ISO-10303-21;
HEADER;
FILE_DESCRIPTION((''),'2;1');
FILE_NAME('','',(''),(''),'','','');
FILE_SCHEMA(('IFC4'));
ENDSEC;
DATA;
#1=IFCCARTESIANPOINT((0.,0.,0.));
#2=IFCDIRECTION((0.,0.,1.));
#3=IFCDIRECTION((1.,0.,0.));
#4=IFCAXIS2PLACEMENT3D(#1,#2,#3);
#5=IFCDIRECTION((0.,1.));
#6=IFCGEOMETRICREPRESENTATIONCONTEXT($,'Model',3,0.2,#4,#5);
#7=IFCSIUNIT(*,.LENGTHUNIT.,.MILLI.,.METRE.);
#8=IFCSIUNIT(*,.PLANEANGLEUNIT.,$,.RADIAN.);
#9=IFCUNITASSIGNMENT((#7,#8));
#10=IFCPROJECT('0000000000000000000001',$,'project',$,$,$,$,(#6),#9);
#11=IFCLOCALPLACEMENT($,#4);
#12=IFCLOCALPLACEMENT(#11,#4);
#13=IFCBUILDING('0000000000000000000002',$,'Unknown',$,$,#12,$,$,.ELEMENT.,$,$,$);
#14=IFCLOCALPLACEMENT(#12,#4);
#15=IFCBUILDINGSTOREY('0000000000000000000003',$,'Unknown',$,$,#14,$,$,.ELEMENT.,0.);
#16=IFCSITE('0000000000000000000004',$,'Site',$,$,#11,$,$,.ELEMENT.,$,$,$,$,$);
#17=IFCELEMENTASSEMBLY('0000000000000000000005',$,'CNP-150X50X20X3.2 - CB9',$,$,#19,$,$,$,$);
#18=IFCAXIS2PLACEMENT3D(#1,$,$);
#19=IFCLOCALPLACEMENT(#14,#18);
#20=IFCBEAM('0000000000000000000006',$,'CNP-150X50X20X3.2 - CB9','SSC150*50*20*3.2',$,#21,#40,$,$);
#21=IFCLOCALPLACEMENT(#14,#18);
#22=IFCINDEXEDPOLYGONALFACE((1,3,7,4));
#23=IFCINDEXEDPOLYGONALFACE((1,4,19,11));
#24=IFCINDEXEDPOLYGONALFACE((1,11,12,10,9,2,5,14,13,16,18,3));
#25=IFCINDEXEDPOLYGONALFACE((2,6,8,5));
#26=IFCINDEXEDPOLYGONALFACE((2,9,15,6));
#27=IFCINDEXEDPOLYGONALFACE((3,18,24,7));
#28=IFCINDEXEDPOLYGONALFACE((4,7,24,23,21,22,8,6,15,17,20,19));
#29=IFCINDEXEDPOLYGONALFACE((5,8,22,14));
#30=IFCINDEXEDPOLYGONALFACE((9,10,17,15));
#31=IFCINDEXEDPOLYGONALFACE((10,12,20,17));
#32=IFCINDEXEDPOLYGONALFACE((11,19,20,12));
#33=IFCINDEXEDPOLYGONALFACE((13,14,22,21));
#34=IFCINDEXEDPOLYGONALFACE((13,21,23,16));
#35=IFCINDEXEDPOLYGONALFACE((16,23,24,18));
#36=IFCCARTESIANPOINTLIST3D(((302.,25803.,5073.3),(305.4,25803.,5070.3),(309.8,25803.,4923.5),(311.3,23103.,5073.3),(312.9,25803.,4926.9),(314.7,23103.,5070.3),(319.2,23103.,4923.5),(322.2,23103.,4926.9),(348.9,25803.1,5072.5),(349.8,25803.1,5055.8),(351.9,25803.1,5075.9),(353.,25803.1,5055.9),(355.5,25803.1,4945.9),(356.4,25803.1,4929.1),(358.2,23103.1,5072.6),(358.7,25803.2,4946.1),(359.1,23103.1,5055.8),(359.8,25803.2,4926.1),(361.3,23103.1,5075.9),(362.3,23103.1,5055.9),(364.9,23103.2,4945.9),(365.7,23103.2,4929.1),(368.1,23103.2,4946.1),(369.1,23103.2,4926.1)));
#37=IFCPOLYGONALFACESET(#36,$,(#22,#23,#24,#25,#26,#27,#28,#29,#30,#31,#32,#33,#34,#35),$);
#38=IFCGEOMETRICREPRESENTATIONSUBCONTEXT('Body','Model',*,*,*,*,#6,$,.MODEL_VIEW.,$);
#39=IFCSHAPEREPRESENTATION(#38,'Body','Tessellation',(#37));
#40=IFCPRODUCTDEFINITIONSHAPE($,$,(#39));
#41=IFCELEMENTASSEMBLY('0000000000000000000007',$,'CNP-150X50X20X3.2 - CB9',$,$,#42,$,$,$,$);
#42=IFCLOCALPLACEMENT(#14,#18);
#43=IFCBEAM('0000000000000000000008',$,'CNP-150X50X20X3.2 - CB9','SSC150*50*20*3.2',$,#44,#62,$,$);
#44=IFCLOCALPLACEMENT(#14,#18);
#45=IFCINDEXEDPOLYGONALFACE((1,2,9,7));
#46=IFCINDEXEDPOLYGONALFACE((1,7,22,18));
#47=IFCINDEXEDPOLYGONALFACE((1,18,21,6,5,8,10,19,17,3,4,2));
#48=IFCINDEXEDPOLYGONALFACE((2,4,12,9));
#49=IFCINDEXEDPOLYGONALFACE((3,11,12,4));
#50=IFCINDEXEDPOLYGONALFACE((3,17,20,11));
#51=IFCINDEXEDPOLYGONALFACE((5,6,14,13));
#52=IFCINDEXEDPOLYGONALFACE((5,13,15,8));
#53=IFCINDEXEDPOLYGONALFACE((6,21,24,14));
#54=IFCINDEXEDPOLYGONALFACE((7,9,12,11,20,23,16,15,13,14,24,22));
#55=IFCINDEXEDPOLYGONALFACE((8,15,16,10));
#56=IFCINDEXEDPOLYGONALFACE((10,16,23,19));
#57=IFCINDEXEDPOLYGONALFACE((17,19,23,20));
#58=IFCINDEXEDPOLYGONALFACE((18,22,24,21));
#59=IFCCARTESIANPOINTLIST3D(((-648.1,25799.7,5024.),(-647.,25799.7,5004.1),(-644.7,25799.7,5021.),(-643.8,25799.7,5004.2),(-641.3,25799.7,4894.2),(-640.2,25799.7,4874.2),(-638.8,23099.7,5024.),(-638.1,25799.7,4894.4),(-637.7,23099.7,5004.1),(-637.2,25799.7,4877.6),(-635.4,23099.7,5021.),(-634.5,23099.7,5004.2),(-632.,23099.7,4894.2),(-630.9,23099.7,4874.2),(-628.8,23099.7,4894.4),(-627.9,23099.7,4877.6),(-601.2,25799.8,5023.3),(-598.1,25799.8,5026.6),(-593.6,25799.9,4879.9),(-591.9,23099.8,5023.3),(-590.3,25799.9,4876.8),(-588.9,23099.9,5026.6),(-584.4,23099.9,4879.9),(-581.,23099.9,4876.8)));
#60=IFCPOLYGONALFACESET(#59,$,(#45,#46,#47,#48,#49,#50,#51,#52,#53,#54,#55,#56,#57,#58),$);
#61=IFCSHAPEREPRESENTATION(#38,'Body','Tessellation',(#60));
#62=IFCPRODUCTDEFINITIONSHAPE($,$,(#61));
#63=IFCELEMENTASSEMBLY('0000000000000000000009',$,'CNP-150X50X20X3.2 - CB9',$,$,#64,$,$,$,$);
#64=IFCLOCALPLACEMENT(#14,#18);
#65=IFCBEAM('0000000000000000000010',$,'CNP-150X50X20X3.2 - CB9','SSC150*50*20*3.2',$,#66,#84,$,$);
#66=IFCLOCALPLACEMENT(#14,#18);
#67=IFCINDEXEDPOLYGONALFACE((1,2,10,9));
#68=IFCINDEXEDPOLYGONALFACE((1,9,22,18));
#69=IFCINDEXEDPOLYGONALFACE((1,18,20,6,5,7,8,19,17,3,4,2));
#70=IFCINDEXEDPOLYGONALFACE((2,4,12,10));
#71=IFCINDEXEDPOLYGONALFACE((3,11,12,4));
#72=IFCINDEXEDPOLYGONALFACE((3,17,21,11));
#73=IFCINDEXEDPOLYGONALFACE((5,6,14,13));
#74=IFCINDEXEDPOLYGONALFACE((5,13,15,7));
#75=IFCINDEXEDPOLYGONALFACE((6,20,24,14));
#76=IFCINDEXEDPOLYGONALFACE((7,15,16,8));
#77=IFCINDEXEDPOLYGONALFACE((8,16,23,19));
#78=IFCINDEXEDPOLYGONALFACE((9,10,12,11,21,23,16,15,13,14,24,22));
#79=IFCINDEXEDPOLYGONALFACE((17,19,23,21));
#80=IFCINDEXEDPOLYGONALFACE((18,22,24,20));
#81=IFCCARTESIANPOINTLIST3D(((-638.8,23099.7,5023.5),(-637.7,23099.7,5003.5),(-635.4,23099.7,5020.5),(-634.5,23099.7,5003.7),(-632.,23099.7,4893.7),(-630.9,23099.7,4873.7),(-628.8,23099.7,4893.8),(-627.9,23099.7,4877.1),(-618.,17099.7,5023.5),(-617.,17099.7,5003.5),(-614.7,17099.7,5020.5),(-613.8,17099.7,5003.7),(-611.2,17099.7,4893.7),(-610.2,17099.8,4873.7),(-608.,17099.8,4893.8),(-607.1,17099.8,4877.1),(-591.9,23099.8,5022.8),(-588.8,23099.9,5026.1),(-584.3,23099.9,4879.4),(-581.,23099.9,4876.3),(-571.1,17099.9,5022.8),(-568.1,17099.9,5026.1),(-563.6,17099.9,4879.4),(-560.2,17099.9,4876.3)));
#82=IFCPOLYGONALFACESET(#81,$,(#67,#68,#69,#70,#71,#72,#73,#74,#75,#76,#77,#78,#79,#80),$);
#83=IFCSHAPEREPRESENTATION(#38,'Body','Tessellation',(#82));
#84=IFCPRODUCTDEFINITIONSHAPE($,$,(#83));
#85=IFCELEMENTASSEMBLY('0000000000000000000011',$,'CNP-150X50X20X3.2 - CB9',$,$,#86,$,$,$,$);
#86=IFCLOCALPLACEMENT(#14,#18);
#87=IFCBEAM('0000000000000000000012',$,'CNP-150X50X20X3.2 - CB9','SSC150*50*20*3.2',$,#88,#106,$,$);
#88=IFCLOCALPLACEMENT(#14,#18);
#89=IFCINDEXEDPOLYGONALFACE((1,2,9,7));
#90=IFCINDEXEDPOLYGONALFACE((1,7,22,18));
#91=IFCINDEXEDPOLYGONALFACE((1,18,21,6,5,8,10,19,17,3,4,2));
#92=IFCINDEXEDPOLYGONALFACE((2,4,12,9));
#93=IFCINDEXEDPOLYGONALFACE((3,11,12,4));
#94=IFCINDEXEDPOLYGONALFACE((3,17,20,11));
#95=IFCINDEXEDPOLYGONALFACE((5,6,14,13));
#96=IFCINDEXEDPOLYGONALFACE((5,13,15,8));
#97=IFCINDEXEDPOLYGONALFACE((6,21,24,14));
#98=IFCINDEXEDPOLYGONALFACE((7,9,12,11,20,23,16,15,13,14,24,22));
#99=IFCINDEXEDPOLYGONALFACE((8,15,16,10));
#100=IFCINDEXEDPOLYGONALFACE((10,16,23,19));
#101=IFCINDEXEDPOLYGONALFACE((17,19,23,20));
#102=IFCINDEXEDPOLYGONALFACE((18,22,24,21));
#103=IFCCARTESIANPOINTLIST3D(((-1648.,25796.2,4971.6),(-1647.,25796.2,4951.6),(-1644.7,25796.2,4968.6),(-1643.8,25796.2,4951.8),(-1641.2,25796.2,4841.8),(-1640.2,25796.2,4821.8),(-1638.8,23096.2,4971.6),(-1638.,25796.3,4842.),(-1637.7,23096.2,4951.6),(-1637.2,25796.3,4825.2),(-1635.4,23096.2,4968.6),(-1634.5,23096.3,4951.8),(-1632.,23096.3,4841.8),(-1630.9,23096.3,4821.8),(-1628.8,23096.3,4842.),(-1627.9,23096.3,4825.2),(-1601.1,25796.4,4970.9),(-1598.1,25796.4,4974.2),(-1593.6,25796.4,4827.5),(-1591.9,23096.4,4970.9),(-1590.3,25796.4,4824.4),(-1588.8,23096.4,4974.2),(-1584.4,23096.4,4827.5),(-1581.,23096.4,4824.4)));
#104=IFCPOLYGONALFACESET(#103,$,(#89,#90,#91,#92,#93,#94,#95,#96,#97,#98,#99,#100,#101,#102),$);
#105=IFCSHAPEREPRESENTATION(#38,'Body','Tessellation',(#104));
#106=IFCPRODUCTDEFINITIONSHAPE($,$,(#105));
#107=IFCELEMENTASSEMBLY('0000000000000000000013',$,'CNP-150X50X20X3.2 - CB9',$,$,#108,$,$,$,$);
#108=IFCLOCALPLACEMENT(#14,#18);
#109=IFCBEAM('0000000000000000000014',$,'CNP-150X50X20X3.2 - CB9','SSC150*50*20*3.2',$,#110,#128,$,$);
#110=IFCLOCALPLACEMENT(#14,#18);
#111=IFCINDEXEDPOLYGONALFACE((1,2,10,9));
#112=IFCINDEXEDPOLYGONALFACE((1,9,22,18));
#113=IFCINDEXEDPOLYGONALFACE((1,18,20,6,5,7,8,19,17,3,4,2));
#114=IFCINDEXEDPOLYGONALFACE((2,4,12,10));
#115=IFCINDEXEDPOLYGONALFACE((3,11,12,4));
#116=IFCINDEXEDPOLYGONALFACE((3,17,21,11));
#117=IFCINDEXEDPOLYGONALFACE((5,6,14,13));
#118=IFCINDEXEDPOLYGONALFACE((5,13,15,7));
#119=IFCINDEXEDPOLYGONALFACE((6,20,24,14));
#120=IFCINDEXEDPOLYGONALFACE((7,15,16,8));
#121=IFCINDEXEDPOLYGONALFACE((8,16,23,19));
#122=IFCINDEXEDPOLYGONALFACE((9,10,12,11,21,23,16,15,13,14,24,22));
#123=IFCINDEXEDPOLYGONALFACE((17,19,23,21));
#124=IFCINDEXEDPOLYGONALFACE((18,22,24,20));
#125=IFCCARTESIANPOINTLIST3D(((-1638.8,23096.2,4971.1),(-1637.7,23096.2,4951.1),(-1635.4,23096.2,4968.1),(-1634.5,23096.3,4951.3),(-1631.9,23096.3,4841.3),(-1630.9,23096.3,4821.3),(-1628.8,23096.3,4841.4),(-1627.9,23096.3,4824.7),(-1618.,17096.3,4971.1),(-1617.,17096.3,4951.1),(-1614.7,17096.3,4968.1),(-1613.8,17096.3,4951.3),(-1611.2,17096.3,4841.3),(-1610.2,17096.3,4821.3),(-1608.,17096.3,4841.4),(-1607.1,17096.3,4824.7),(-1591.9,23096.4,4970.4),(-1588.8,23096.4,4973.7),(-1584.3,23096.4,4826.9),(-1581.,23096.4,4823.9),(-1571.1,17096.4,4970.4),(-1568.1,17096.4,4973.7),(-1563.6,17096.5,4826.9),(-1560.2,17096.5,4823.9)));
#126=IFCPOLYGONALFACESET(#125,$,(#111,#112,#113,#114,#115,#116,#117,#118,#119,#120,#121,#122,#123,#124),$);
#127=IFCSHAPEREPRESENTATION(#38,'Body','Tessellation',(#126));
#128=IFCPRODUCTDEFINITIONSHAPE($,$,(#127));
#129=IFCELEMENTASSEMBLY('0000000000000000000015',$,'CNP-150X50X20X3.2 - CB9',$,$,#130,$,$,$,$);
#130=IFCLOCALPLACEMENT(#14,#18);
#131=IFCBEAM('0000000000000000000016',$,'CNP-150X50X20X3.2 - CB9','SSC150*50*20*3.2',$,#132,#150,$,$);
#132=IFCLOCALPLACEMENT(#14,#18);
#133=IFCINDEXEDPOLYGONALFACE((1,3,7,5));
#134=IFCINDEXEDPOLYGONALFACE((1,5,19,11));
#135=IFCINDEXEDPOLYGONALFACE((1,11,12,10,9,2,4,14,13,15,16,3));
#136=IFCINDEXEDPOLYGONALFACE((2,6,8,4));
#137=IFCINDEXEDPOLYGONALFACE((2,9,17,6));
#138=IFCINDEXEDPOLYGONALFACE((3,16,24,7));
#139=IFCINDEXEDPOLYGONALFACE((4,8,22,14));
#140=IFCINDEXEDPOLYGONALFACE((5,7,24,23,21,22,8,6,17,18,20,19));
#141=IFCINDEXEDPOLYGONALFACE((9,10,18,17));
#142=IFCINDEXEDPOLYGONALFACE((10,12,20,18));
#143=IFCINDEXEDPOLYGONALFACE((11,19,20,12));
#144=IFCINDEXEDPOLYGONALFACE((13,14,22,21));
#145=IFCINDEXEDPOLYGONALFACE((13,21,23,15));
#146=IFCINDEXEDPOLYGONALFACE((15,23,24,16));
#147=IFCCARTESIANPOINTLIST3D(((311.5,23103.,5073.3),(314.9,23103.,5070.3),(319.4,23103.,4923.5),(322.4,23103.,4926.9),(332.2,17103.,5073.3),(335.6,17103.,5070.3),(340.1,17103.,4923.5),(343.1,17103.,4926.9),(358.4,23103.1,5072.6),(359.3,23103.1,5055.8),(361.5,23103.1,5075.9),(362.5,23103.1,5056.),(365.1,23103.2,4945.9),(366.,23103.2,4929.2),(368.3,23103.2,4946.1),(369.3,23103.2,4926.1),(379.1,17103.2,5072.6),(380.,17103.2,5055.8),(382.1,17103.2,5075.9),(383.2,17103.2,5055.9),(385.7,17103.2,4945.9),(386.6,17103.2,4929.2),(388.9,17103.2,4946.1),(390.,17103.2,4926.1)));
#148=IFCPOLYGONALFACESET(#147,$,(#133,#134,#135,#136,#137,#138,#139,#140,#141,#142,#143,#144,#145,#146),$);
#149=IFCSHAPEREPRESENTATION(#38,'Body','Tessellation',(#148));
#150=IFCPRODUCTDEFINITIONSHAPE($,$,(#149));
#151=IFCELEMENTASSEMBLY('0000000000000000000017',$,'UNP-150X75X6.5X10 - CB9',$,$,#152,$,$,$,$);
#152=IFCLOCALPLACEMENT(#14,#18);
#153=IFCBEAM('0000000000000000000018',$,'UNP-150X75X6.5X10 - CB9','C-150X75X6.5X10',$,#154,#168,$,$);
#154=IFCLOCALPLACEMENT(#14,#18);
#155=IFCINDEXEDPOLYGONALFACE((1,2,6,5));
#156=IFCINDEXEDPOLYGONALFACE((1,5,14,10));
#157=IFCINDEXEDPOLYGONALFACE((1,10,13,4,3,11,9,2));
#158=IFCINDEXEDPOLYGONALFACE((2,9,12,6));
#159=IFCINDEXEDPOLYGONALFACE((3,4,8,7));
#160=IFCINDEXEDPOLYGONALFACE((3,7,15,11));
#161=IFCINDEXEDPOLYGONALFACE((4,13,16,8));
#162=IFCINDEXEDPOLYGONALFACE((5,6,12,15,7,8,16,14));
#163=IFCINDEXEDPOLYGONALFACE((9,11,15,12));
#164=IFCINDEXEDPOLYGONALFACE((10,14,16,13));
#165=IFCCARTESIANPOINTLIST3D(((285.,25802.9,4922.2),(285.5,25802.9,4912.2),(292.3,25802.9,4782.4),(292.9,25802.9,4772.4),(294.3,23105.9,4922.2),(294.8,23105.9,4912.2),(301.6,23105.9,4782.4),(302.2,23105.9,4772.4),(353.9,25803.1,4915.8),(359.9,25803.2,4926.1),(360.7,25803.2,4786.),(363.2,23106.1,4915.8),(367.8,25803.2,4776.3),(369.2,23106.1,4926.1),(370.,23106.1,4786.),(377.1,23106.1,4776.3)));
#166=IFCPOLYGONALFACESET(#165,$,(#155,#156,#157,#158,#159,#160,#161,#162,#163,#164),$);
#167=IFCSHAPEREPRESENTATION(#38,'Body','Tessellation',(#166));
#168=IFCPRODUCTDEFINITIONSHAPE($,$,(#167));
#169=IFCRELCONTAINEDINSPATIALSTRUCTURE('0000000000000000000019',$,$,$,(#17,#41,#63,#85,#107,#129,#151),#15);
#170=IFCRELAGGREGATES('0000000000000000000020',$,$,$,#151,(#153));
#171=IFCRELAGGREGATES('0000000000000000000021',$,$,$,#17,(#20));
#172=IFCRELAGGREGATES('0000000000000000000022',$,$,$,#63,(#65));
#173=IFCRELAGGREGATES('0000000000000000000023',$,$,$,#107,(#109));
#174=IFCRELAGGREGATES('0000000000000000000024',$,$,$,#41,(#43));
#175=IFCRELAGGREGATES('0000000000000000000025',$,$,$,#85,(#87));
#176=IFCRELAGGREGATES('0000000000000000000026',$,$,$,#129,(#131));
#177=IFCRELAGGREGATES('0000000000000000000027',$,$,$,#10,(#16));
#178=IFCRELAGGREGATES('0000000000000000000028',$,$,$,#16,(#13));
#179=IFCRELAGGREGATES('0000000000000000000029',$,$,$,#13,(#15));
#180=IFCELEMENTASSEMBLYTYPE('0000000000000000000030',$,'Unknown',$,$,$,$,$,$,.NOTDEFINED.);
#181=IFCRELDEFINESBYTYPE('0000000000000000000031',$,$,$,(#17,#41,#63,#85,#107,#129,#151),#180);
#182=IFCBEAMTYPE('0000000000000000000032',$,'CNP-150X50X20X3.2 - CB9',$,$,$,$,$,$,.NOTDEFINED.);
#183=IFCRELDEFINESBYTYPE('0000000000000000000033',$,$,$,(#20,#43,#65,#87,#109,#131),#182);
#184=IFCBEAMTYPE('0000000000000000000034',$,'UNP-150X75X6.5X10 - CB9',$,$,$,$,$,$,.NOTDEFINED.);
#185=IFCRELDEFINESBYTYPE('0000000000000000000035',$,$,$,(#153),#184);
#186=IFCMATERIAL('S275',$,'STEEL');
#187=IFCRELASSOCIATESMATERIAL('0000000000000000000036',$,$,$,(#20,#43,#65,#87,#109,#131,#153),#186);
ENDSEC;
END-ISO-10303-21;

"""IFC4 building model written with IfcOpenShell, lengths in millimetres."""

from ifc_helpers import new_model, si_unit, direction, frame, origin_with_axes, origin_2d_with_axis, place, context, subcontext, project, spatial, polyline, c_section, outline, extrude, material, material_profile, profile_set, profile_usage, type_object, element, aggregate, save


model = new_model("IFC4")

# Units and contexts
model_context = context("Model", 3, precision=0.2, world=origin_with_axes(), true_north=direction((0.0, 1.0)))
body_context = subcontext(model_context, "Body", "Model", "MODEL_VIEW")
ifc_project = project(units=[si_unit("LENGTHUNIT", "METRE", prefix="MILLI"), si_unit("PLANEANGLEUNIT", "RADIAN")], contexts=[model_context])

# Site, building, storey
site_placement = place(None, origin_with_axes())
site = spatial("IfcSite", under=ifc_project, at=site_placement, Name="Site", CompositionType="ELEMENT")
building_placement = place(site_placement, origin_with_axes())
building = spatial("IfcBuilding", under=site, at=building_placement, Name="Unknown", CompositionType="ELEMENT")
storey_placement = place(building_placement, origin_with_axes())
storey = spatial("IfcBuildingStorey", under=building, at=storey_placement, Name="Unknown", CompositionType="ELEMENT", Elevation=0.0)

# Element assemblies, beams
element_assembly_type = type_object("IfcElementAssemblyType", Name="Unknown", PredefinedType="NOTDEFINED")
assembly_1_placement = place(storey_placement, frame((330.9, 25803.1, 4999.7), z_axis=(0.998624, 0.003452, 0.052336), x_axis=(0.003456, -0.999994, 0.000001)))
assembly_1 = element("IfcElementAssembly", 1, at=assembly_1_placement, inside=storey, type_object=element_assembly_type, Name="CNP-150X50X20X3.2 - CB9")
ifc_material_1 = material(Name="S275", Category="STEEL")
ifc_material_profile_1 = material_profile(ifc_material_1, c_section(Depth=150.0, Width=50.0, WallThickness=3.2, Girth=20.0, at=origin_2d_with_axis()), Name="SSC150*50*20*3.2")
ifc_profile_set_1 = profile_set([ifc_material_profile_1])
ifc_profile_usage_1 = profile_usage(ifc_profile_set_1, cardinal=8)
beam_type_1 = type_object("IfcBeamType", Name="CNP-150X50X20X3.2 - CB9", PredefinedType="NOTDEFINED")
beam_1_placement = place(assembly_1_placement, origin_with_axes())
beam_1 = element("IfcBeam", 2, at=beam_1_placement, type_object=beam_type_1, material=ifc_profile_usage_1, Name="CNP-150X50X20X3.2 - CB9", Description="SSC150*50*20*3.2", context=body_context, shape_type="SolidModel", body=[
    extrude(c_section(Depth=150.0, Width=50.0, WallThickness=3.2, Girth=20.0, at=origin_2d_with_axis()), frame((0.0, 0.0, 0.0), z_axis=(-1.0, 0.0, 0.0), x_axis=(0.0, 0.0, 1.0)), (0.0, 0.0, -1.0), 2700.0),
])
assembly_2_placement = place(storey_placement, frame((-619.2, 25799.8, 4950.4), z_axis=(-0.998624, -0.003427, -0.052336), x_axis=(0.003432, -0.999994, 0.0)))
assembly_2 = element("IfcElementAssembly", 3, at=assembly_2_placement, inside=storey, type_object=element_assembly_type, Name="CNP-150X50X20X3.2 - CB9")
beam_2_placement = place(assembly_2_placement, origin_with_axes())
beam_2 = element("IfcBeam", 4, at=beam_2_placement, type_object=beam_type_1, material=ifc_profile_usage_1, Name="CNP-150X50X20X3.2 - CB9", Description="SSC150*50*20*3.2", context=body_context, shape_type="SolidModel", body=[
    extrude(c_section(Depth=150.0, Width=50.0, WallThickness=3.2, Girth=20.0, at=origin_2d_with_axis()), frame((0.0, 0.0, 0.0), z_axis=(-1.0, 0.0, 0.0), x_axis=(0.0, 0.0, 1.0)), (0.0, 0.0, -1.0), 2700.0),
])
assembly_3_placement = place(storey_placement, frame((-609.9, 23099.8, 4949.9), z_axis=(-0.998624, -0.003452, -0.052336), x_axis=(0.003456, -0.999994, 0.0)))
assembly_3 = element("IfcElementAssembly", 5, at=assembly_3_placement, inside=storey, type_object=element_assembly_type, Name="CNP-150X50X20X3.2 - CB9")
beam_3_placement = place(assembly_3_placement, origin_with_axes())
beam_3 = element("IfcBeam", 6, at=beam_3_placement, type_object=beam_type_1, material=ifc_profile_usage_1, Name="CNP-150X50X20X3.2 - CB9", Description="SSC150*50*20*3.2", context=body_context, shape_type="SolidModel", body=[
    extrude(c_section(Depth=150.0, Width=50.0, WallThickness=3.2, Girth=20.0, at=origin_2d_with_axis()), frame((0.0, 0.0, 0.0), z_axis=(-1.0, 0.0, 0.0), x_axis=(0.0, 0.0, 1.0)), (0.0, 0.0, -1.0), 6000.0),
])
assembly_4_placement = place(storey_placement, frame((-1619.2, 25796.3, 4898.0), z_axis=(-0.998624, -0.003427, -0.052336), x_axis=(0.003432, -0.999994, 0.0)))
assembly_4 = element("IfcElementAssembly", 7, at=assembly_4_placement, inside=storey, type_object=element_assembly_type, Name="CNP-150X50X20X3.2 - CB9")
beam_4_placement = place(assembly_4_placement, origin_with_axes())
beam_4 = element("IfcBeam", 8, at=beam_4_placement, type_object=beam_type_1, material=ifc_profile_usage_1, Name="CNP-150X50X20X3.2 - CB9", Description="SSC150*50*20*3.2", context=body_context, shape_type="SolidModel", body=[
    extrude(c_section(Depth=150.0, Width=50.0, WallThickness=3.2, Girth=20.0, at=origin_2d_with_axis()), frame((0.0, 0.0, 0.0), z_axis=(-1.0, 0.0, 0.0), x_axis=(0.0, 0.0, 1.0)), (0.0, 0.0, -1.0), 2700.0),
])
assembly_5_placement = place(storey_placement, frame((-1609.9, 23096.3, 4897.5), z_axis=(-0.998624, -0.003452, -0.052336), x_axis=(0.003456, -0.999994, 0.0)))
assembly_5 = element("IfcElementAssembly", 9, at=assembly_5_placement, inside=storey, type_object=element_assembly_type, Name="CNP-150X50X20X3.2 - CB9")
beam_5_placement = place(assembly_5_placement, origin_with_axes())
beam_5 = element("IfcBeam", 10, at=beam_5_placement, type_object=beam_type_1, material=ifc_profile_usage_1, Name="CNP-150X50X20X3.2 - CB9", Description="SSC150*50*20*3.2", context=body_context, shape_type="SolidModel", body=[
    extrude(c_section(Depth=150.0, Width=50.0, WallThickness=3.2, Girth=20.0, at=origin_2d_with_axis()), frame((0.0, 0.0, 0.0), z_axis=(-1.0, 0.0, 0.0), x_axis=(0.0, 0.0, 1.0)), (0.0, 0.0, -1.0), 6000.0),
])
assembly_6_placement = place(storey_placement, frame((340.4, 23103.1, 4999.7), z_axis=(0.998624, 0.003441, 0.052336), x_axis=(0.003445, -0.999994, -0.000001)))
assembly_6 = element("IfcElementAssembly", 11, at=assembly_6_placement, inside=storey, type_object=element_assembly_type, Name="CNP-150X50X20X3.2 - CB9")
beam_6_placement = place(assembly_6_placement, origin_with_axes())
beam_6 = element("IfcBeam", 12, at=beam_6_placement, type_object=beam_type_1, material=ifc_profile_usage_1, Name="CNP-150X50X20X3.2 - CB9", Description="SSC150*50*20*3.2", context=body_context, shape_type="SolidModel", body=[
    extrude(c_section(Depth=150.0, Width=50.0, WallThickness=3.2, Girth=20.0, at=origin_2d_with_axis()), frame((0.0, 0.0, 0.0), z_axis=(-1.0, 0.0, 0.0), x_axis=(0.0, 0.0, 1.0)), (0.0, 0.0, -1.0), 6000.0),
])
assembly_7_placement = place(storey_placement, frame((335.7, 23106.0, 4849.3), z_axis=(-0.998624, -0.00344, -0.052336), x_axis=(-0.003445, 0.999994, 0.000001)))
assembly_7 = element("IfcElementAssembly", 13, at=assembly_7_placement, inside=storey, type_object=element_assembly_type, Name="UNP-150X75X6.5X10 - CB9")
ifc_material_profile_2 = material_profile(ifc_material_1, outline(polyline([(-37.5, -75.0), (37.5, -75.0), (37.5, -65.0), (-31.0, -65.0), (-31.0, 65.0), (37.5, 65.0), (37.5, 75.0), (-37.5, 75.0), (-37.5, -75.0)])), Name="C-150X75X6.5X10")
ifc_profile_set_2 = profile_set([ifc_material_profile_2])
ifc_profile_usage_2 = profile_usage(ifc_profile_set_2, cardinal=8)
beam_type_2 = type_object("IfcBeamType", Name="UNP-150X75X6.5X10 - CB9", PredefinedType="NOTDEFINED")
beam_7_placement = place(assembly_7_placement, origin_with_axes())
beam_7 = element("IfcBeam", 14, at=beam_7_placement, type_object=beam_type_2, material=ifc_profile_usage_2, Name="UNP-150X75X6.5X10 - CB9", Description="C-150X75X6.5X10", context=body_context, shape_type="SolidModel", body=[
    extrude(outline(polyline([(-37.5, -75.0), (37.5, -75.0), (37.5, -65.0), (-31.0, -65.0), (-31.0, 65.0), (37.5, 65.0), (37.5, 75.0), (-37.5, 75.0), (-37.5, -75.0)])), frame((0.0, 0.0, 0.0), z_axis=(-1.0, 0.0, 0.0), x_axis=(0.0, 0.0, 1.0)), (0.0, 0.0, -1.0), 2697.1),
])
aggregate(assembly_7, [beam_7])

aggregate(assembly_1, [beam_1])
aggregate(assembly_3, [beam_3])
aggregate(assembly_5, [beam_5])
aggregate(assembly_2, [beam_2])
aggregate(assembly_4, [beam_4])
aggregate(assembly_6, [beam_6])

save(model, "model.ifc")
